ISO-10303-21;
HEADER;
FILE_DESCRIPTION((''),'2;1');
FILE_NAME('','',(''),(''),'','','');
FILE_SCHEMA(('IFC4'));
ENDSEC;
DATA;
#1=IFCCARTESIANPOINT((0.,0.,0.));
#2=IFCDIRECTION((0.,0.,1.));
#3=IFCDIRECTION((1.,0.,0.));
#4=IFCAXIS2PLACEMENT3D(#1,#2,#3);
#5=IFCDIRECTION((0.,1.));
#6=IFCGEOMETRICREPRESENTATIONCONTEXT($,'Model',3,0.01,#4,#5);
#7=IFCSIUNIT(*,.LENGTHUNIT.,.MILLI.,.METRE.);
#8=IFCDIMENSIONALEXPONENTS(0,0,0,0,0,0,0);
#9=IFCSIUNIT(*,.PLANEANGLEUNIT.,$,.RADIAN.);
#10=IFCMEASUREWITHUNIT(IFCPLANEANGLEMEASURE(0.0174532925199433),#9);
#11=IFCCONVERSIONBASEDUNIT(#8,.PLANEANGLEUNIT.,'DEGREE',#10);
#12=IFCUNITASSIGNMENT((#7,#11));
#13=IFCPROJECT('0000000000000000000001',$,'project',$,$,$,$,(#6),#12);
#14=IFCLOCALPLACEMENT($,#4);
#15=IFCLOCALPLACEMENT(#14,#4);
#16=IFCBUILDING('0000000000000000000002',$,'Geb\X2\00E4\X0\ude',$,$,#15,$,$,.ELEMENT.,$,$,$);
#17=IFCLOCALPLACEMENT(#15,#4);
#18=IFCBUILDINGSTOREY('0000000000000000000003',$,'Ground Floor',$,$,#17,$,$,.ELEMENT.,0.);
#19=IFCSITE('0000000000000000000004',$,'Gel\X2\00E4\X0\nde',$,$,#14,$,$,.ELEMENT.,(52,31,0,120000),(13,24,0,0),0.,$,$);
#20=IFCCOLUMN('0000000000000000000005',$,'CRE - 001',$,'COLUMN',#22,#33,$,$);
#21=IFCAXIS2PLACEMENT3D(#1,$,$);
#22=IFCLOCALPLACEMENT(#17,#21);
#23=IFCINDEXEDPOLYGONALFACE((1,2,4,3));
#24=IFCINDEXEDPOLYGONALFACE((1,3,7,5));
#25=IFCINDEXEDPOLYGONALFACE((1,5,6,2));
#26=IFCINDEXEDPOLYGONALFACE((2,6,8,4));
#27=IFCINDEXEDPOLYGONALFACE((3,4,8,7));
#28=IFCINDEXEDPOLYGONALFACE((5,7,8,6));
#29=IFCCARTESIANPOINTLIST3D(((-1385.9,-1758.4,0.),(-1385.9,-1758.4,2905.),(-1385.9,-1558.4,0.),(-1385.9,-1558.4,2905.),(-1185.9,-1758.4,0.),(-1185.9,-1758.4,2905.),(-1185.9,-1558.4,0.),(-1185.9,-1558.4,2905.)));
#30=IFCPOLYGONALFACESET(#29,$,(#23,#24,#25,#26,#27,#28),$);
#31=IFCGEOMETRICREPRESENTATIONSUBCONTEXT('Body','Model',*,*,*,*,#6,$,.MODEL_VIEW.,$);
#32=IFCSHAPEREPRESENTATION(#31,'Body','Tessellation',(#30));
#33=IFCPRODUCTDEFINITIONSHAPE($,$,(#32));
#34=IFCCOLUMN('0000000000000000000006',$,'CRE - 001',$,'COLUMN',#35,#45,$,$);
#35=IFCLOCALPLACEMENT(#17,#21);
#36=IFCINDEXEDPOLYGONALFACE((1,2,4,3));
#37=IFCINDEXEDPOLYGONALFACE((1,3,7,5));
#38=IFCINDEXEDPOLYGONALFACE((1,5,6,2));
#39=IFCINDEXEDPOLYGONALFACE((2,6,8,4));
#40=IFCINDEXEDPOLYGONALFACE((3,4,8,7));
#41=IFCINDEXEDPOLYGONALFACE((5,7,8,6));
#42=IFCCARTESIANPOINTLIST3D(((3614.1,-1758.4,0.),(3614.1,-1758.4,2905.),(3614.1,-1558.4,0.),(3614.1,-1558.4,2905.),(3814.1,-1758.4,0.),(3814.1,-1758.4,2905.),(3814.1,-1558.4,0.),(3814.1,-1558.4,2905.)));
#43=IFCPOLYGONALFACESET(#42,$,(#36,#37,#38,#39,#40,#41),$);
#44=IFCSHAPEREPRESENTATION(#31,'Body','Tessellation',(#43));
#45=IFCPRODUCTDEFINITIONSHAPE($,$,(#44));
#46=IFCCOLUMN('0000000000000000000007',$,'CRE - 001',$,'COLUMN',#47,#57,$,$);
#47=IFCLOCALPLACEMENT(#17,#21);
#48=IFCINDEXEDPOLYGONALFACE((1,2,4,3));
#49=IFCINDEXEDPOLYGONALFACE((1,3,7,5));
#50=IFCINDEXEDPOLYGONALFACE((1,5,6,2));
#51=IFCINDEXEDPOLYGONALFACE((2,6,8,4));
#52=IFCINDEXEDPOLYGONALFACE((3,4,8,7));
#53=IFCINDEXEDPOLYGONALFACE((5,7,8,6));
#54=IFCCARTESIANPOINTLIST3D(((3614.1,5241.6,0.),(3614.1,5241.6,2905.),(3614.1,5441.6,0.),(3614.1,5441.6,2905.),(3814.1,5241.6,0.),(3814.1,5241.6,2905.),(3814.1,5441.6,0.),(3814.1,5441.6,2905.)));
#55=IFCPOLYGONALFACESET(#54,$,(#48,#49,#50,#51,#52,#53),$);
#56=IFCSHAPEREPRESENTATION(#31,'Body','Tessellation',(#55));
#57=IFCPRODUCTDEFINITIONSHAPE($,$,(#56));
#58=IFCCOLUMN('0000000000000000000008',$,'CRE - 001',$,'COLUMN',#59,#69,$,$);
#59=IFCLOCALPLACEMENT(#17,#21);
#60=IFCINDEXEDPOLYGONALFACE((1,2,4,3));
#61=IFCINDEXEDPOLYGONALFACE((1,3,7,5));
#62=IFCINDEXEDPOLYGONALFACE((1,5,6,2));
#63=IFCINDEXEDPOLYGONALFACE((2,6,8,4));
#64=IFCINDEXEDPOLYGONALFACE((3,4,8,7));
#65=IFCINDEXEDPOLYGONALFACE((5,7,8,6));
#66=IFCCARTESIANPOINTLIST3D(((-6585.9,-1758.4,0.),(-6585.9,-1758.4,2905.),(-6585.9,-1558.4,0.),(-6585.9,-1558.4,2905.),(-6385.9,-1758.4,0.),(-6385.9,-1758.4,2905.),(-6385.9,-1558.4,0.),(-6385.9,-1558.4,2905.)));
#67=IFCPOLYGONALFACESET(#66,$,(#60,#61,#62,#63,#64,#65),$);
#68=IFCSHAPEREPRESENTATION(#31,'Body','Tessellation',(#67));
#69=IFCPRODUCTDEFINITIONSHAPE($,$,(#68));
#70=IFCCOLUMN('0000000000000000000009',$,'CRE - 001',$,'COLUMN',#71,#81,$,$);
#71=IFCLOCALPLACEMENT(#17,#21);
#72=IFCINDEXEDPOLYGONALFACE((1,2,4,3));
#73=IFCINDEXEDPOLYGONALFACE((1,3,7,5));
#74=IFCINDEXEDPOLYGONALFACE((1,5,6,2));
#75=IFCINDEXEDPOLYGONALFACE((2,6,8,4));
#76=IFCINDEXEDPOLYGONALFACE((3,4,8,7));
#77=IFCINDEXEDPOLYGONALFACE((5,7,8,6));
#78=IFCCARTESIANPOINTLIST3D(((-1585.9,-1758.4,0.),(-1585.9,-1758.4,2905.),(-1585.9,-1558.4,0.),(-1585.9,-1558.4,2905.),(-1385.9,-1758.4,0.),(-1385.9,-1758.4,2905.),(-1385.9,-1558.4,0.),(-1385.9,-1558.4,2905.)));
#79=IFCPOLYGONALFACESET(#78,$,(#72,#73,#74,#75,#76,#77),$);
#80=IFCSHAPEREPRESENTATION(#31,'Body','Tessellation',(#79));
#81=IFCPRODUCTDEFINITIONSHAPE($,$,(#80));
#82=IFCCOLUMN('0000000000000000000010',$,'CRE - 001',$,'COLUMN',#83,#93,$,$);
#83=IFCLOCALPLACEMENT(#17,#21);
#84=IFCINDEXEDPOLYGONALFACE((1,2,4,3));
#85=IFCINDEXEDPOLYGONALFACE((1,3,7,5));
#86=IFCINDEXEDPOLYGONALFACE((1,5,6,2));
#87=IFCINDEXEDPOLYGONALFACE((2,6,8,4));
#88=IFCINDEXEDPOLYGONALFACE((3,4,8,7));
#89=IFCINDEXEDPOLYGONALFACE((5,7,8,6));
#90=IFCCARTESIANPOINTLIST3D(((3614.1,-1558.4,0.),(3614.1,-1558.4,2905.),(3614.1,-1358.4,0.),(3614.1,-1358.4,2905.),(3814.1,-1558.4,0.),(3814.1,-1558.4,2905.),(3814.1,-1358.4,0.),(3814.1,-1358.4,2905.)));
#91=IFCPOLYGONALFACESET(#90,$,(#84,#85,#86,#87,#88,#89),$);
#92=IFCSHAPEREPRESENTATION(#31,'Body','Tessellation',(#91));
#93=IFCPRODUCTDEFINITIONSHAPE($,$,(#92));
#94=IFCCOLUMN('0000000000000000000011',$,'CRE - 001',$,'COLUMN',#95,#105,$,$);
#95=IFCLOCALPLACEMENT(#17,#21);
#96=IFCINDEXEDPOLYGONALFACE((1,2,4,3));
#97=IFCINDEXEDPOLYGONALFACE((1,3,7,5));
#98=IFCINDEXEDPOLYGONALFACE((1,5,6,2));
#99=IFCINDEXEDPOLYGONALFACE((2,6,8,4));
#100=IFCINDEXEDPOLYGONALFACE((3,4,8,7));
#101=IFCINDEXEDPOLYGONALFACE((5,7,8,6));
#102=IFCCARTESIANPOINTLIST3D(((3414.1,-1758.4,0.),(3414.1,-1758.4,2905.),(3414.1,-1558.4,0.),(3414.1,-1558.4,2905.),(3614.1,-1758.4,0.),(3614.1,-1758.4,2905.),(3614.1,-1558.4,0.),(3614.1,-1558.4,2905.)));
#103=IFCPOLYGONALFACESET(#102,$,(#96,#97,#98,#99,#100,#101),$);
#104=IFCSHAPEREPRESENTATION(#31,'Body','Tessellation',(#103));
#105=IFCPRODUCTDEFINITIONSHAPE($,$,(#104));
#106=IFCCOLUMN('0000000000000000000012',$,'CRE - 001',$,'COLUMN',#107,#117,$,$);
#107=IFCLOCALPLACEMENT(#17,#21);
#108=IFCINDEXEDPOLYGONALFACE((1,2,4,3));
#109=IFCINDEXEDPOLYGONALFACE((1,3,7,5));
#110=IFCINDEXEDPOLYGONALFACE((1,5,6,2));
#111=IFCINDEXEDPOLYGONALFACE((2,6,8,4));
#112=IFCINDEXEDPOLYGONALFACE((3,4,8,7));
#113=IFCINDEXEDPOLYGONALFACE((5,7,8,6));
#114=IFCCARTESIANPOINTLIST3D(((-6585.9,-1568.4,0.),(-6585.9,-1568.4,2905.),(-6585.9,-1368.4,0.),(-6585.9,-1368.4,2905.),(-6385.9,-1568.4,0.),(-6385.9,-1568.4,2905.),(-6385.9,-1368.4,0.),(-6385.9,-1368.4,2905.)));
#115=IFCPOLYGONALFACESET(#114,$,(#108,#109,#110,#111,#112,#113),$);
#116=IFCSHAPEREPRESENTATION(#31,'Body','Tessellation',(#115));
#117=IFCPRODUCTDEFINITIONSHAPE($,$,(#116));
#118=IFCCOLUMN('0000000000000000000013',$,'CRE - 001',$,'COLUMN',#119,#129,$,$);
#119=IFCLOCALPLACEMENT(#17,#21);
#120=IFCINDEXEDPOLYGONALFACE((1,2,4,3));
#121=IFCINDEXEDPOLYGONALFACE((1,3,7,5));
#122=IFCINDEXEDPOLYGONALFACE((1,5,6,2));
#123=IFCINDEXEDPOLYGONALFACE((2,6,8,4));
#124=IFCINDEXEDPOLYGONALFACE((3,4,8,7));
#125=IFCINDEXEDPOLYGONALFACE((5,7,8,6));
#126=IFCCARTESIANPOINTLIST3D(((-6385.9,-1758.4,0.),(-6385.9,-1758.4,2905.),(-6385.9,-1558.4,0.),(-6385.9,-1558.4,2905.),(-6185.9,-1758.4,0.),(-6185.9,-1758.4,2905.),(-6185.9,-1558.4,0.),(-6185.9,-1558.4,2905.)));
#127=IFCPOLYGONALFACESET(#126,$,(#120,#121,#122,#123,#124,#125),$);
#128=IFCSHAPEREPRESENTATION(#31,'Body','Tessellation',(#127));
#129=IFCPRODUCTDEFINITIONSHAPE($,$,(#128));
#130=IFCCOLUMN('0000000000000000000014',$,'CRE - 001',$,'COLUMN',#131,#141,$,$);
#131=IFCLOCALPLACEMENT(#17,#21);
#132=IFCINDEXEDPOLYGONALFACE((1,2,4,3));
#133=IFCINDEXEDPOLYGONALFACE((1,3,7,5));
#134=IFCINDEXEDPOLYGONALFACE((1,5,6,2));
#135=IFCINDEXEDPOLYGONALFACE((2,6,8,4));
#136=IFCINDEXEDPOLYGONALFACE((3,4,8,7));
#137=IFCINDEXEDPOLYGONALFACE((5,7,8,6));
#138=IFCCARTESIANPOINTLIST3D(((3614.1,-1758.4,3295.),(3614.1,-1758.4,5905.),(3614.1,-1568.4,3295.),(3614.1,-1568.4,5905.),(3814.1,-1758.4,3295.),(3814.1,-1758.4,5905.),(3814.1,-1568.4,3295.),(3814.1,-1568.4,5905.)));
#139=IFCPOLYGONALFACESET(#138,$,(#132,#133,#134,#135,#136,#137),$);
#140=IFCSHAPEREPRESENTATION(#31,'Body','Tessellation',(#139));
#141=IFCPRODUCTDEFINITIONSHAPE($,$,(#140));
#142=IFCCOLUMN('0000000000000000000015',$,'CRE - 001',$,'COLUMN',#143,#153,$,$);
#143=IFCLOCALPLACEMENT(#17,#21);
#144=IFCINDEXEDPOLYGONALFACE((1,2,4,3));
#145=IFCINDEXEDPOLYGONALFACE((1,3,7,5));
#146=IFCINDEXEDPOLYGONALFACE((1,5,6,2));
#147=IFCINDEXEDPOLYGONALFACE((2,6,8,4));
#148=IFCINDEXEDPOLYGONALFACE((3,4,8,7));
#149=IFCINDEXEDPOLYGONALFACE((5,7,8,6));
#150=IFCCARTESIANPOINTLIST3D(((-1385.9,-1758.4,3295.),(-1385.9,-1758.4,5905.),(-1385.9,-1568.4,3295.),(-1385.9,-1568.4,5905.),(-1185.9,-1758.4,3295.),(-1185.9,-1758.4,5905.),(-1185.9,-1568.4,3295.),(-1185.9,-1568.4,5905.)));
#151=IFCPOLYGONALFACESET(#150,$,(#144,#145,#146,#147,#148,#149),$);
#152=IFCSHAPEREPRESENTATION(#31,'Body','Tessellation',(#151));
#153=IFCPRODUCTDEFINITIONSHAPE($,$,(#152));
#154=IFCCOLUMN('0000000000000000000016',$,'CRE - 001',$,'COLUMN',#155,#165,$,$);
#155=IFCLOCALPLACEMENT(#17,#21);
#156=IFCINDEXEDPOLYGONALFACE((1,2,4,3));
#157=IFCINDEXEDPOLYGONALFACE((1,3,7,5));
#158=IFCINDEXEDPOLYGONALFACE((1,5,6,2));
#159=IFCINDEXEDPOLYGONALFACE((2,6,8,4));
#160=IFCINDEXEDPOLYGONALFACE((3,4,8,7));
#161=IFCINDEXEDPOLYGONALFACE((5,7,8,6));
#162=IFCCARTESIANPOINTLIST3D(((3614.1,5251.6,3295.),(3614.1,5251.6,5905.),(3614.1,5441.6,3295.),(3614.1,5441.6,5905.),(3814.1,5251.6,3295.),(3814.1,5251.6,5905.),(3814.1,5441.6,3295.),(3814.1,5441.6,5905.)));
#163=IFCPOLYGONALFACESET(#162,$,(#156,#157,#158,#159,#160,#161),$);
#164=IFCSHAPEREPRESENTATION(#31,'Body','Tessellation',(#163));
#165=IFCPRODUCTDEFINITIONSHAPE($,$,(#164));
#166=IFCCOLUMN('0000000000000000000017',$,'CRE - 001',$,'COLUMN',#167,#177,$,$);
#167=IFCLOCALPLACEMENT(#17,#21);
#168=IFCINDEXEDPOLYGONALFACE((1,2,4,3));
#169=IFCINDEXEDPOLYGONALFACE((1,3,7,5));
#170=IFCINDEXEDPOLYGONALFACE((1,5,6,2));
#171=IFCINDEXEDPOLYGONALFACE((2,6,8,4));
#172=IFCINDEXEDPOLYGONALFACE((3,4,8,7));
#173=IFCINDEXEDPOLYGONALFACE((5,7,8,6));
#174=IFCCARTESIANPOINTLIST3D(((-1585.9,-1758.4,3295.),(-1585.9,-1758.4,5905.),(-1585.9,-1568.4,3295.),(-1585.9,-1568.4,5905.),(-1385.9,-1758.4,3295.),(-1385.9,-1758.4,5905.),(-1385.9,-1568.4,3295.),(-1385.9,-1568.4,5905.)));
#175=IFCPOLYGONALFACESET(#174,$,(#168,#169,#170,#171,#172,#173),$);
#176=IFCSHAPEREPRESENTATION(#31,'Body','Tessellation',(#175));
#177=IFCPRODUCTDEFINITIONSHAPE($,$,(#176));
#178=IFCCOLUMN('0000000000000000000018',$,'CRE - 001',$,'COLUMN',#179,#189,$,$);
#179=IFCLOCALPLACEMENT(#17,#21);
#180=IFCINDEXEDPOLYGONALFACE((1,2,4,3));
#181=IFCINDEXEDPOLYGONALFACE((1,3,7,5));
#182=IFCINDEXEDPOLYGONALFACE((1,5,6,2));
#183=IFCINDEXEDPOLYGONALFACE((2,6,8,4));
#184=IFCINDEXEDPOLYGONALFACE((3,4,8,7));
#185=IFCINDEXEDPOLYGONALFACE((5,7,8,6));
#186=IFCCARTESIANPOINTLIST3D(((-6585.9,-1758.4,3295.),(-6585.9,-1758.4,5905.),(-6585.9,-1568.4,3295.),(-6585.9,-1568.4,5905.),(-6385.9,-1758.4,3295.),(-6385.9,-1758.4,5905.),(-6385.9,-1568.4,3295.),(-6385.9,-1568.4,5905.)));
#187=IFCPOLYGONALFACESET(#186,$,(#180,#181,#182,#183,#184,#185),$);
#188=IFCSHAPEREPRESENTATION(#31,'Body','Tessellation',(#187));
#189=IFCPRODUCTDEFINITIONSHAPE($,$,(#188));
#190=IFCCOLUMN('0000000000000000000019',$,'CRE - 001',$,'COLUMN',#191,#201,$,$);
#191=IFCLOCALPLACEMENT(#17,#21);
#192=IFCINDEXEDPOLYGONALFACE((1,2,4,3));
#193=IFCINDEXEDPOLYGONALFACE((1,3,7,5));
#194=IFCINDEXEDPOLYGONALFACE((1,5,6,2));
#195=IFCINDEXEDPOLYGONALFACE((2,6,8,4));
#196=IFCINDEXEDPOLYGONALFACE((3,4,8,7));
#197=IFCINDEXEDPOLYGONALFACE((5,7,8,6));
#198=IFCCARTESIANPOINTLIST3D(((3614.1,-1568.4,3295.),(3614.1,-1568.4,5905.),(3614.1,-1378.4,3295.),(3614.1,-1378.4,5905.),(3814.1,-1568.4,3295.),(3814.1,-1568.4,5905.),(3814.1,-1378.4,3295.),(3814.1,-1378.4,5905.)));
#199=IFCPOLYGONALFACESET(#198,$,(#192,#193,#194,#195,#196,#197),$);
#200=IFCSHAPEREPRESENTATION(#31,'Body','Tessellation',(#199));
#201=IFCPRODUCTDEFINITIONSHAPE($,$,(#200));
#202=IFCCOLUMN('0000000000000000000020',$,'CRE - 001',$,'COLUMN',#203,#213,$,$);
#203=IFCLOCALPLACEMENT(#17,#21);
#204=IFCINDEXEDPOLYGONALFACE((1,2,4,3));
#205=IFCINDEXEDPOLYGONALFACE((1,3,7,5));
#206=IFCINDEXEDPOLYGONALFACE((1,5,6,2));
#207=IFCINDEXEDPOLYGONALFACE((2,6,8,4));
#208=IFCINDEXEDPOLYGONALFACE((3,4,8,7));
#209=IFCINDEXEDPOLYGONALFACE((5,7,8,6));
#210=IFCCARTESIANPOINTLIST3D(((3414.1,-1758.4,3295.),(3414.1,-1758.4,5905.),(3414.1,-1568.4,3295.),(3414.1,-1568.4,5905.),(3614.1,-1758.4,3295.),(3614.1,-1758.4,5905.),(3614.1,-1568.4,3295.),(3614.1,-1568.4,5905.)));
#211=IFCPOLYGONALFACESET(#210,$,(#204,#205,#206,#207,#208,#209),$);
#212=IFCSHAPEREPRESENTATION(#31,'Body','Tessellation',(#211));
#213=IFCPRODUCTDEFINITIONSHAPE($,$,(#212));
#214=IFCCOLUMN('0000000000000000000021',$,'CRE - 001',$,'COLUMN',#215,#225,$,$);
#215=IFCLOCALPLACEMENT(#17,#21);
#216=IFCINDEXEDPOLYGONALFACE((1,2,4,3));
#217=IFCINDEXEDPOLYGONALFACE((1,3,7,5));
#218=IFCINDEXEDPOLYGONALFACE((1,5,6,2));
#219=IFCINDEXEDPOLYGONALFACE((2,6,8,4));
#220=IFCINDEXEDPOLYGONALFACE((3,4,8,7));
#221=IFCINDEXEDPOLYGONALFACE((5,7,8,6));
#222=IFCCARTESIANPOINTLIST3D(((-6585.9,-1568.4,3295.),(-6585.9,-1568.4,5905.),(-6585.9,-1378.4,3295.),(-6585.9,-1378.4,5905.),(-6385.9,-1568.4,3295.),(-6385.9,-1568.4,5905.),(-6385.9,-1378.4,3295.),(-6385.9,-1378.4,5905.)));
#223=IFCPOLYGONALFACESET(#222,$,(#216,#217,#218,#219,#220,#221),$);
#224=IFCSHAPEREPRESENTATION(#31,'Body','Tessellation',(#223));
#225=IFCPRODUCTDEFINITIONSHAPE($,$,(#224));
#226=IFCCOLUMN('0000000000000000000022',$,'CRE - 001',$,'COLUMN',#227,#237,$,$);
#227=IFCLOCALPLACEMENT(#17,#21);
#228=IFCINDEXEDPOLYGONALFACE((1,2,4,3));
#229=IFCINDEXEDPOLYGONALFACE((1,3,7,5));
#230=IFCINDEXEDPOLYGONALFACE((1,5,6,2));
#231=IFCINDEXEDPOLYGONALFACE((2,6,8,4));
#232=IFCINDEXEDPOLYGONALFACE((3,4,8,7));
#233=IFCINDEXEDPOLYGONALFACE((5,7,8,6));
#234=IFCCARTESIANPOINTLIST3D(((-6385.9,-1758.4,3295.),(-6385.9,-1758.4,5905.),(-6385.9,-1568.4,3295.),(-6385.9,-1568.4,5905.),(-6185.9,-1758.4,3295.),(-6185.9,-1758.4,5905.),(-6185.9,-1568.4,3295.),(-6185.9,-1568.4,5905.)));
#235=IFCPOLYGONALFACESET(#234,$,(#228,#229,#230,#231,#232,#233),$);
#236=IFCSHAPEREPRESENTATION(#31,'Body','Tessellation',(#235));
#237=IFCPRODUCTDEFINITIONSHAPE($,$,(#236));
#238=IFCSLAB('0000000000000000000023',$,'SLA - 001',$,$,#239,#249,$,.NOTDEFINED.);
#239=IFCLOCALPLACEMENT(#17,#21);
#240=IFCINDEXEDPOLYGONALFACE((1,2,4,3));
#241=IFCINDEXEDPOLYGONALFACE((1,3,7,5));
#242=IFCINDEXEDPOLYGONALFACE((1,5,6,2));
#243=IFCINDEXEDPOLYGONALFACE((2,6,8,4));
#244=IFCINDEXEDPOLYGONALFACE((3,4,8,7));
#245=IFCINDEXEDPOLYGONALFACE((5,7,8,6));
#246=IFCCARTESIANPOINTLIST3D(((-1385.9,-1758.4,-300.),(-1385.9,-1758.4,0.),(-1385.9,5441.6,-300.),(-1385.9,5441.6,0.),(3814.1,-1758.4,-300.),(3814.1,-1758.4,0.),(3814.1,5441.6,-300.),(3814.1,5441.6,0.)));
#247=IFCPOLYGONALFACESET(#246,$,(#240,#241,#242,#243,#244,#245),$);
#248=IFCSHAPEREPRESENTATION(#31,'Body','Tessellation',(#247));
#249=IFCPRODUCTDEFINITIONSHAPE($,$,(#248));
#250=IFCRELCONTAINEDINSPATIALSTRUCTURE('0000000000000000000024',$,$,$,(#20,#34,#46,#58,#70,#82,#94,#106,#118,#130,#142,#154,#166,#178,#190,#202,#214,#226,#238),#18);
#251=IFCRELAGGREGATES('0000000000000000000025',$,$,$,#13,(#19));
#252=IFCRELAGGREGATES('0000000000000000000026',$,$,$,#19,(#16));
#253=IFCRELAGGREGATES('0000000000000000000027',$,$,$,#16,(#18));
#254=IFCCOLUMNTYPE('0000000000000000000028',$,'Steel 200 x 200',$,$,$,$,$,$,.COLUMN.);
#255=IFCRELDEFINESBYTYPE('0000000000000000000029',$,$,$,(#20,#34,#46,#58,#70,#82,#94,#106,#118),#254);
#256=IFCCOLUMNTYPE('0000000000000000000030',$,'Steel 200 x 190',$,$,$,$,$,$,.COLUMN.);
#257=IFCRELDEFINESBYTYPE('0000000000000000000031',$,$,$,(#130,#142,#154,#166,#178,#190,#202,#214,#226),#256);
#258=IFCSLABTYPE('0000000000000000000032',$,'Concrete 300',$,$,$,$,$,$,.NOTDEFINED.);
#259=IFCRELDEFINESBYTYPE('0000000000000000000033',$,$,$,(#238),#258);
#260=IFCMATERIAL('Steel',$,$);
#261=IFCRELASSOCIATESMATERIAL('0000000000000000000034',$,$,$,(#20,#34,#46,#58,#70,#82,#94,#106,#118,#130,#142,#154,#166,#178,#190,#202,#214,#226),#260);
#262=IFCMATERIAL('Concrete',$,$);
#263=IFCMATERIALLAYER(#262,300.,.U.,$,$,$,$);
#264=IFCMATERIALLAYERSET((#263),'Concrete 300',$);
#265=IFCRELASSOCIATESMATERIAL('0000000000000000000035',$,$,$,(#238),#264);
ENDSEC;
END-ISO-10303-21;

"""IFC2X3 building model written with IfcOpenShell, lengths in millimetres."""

from ifc_helpers import new_model, entity, si_unit, converted_unit, direction, frame, origin_with_axes, origin_2d_with_axis, place, context, subcontext, project, spatial, polyline, rectangle, outline, extrude, material, layer, layer_set, layer_usage, type_object, element, save


model = new_model("IFC2X3")

# Units and contexts
model_context = context("Model", 3, precision=0.01, world=origin_with_axes(), true_north=direction((0.0, 1.0)))
body_context = subcontext(model_context, "Body", "Model", "MODEL_VIEW")
ifc_project = project(units=[si_unit("LENGTHUNIT", "METRE", prefix="MILLI"), converted_unit("PLANEANGLEUNIT", "DEGREE", entity("IfcPlaneAngleMeasure", 0.0174532925199433), si_unit("PLANEANGLEUNIT", "RADIAN"), dimensions=[0, 0, 0, 0, 0, 0, 0])], contexts=[model_context])

# Site, building, storey
site_placement = place(None, origin_with_axes())
site = spatial("IfcSite", under=ifc_project, at=site_placement, Name="Gelände", CompositionType="ELEMENT", RefLatitude=(52, 31, 0, 120000), RefLongitude=(13, 24, 0, 0), RefElevation=0.0)
building_placement = place(site_placement, origin_with_axes())
building = spatial("IfcBuilding", under=site, at=building_placement, Name="Gebäude", CompositionType="ELEMENT")
storey_placement = place(building_placement, origin_with_axes())
storey = spatial("IfcBuildingStorey", under=building, at=storey_placement, Name="Ground Floor", CompositionType="ELEMENT", Elevation=0.0)

# Columns
ifc_material_1 = material(Name="Steel")
column_type_1 = type_object("IfcColumnType", Name="Steel 200 x 200", PredefinedType="COLUMN")
for number, where, z_axis, x_axis, name in (
    (1, (-1285.9, -1658.4, 0.0), (0.0, 0.0, 1.0), (1.0, 0.0, 0.0), "CRE - 001"),
    (2, (3714.1, -1658.4, 0.0), (0.0, 0.0, 1.0), (1.0, 0.0, 0.0), "CRE - 001"),
    (3, (3714.1, 5341.6, 0.0), (0.0, 0.0, 1.0), (1.0, 0.0, 0.0), "CRE - 001"),
    (4, (-6485.9, -1658.4, 0.0), (0.0, 0.0, 1.0), (1.0, 0.0, 0.0), "CRE - 001"),
    (5, (-1485.9, -1658.4, 0.0), (0.0, 0.0, 1.0), (1.0, 0.0, 0.0), "CRE - 001"),
    (6, (3714.1, -1458.4, 0.0), (0.0, 0.0, 1.0), (1.0, 0.0, 0.0), "CRE - 001"),
    (7, (3514.1, -1658.4, 0.0), (0.0, 0.0, 1.0), (1.0, 0.0, 0.0), "CRE - 001"),
    (8, (-6485.9, -1468.4, 0.0), (0.0, 0.0, 1.0), (1.0, 0.0, 0.0), "CRE - 001"),
    (9, (-6285.9, -1658.4, 0.0), (0.0, 0.0, 1.0), (1.0, 0.0, 0.0), "CRE - 001"),
):
    element("IfcColumn", number, at=place(storey_placement, frame(where, z_axis=z_axis, x_axis=x_axis)), inside=storey, type_object=column_type_1, material=ifc_material_1, Name=name, ObjectType="COLUMN", context=body_context, shape_type="SweptSolid", body=[
        extrude(rectangle(XDim=200.0, YDim=200.0, at=origin_2d_with_axis()), origin_with_axes(), (0.0, 0.0, 1.0), 2905.0),
    ])
column_type_2 = type_object("IfcColumnType", Name="Steel 200 x 190", PredefinedType="COLUMN")
for number, where, z_axis, x_axis, name in (
    (10, (3714.1, -1663.4, 3295.0), (0.0, 0.0, 1.0), (1.0, 0.0, 0.0), "CRE - 001"),
    (11, (-1285.9, -1663.4, 3295.0), (0.0, 0.0, 1.0), (1.0, 0.0, 0.0), "CRE - 001"),
    (12, (3714.1, 5346.6, 3295.0), (0.0, 0.0, 1.0), (1.0, 0.0, 0.0), "CRE - 001"),
    (13, (-1485.9, -1663.4, 3295.0), (0.0, 0.0, 1.0), (1.0, 0.0, 0.0), "CRE - 001"),
    (14, (-6485.9, -1663.4, 3295.0), (0.0, 0.0, 1.0), (1.0, 0.0, 0.0), "CRE - 001"),
    (15, (3714.1, -1473.4, 3295.0), (0.0, 0.0, 1.0), (1.0, 0.0, 0.0), "CRE - 001"),
    (16, (3514.1, -1663.4, 3295.0), (0.0, 0.0, 1.0), (1.0, 0.0, 0.0), "CRE - 001"),
    (17, (-6485.9, -1473.4, 3295.0), (0.0, 0.0, 1.0), (1.0, 0.0, 0.0), "CRE - 001"),
    (18, (-6285.9, -1663.4, 3295.0), (0.0, 0.0, 1.0), (1.0, 0.0, 0.0), "CRE - 001"),
):
    element("IfcColumn", number, at=place(storey_placement, frame(where, z_axis=z_axis, x_axis=x_axis)), inside=storey, type_object=column_type_2, material=ifc_material_1, Name=name, ObjectType="COLUMN", context=body_context, shape_type="SweptSolid", body=[
        extrude(rectangle(XDim=200.0, YDim=190.0, at=origin_2d_with_axis()), origin_with_axes(), (0.0, 0.0, 1.0), 2610.0),
    ])

# Slab
ifc_material_2 = material(Name="Concrete")
ifc_layer_1 = layer(ifc_material_2, 300.0, ventilated="UNKNOWN")
ifc_layer_set_1 = layer_set([ifc_layer_1], Name="Concrete 300")
ifc_layer_usage_1 = layer_usage(ifc_layer_set_1, "AXIS3", "NEGATIVE", 300.0)
slab_type_1 = type_object("IfcSlabType", Name="Concrete 300", PredefinedType="NOTDEFINED")
slab_1_placement = place(storey_placement, frame((-1385.9, -1758.4, 0.0), z_axis=(0.0, 0.0, 1.0), x_axis=(1.0, 0.0, 0.0)))
element("IfcSlab", 19, at=slab_1_placement, inside=storey, type_object=slab_type_1, material=ifc_layer_usage_1, Name="SLA - 001", PredefinedType="NOTDEFINED", context=body_context, shape_type="SweptSolid", body=[
    extrude(outline(polyline([(0.0, 0.0), (5200.0, 0.0), (5200.0, 7200.0), (0.0, 7200.0), (0.0, 0.0)])), frame((0.0, 0.0, -300.0), z_axis=(0.0, 0.0, 1.0), x_axis=(1.0, 0.0, 0.0)), (0.0, 0.0, 1.0), 300.0),
])

save(model, "model.ifc")
